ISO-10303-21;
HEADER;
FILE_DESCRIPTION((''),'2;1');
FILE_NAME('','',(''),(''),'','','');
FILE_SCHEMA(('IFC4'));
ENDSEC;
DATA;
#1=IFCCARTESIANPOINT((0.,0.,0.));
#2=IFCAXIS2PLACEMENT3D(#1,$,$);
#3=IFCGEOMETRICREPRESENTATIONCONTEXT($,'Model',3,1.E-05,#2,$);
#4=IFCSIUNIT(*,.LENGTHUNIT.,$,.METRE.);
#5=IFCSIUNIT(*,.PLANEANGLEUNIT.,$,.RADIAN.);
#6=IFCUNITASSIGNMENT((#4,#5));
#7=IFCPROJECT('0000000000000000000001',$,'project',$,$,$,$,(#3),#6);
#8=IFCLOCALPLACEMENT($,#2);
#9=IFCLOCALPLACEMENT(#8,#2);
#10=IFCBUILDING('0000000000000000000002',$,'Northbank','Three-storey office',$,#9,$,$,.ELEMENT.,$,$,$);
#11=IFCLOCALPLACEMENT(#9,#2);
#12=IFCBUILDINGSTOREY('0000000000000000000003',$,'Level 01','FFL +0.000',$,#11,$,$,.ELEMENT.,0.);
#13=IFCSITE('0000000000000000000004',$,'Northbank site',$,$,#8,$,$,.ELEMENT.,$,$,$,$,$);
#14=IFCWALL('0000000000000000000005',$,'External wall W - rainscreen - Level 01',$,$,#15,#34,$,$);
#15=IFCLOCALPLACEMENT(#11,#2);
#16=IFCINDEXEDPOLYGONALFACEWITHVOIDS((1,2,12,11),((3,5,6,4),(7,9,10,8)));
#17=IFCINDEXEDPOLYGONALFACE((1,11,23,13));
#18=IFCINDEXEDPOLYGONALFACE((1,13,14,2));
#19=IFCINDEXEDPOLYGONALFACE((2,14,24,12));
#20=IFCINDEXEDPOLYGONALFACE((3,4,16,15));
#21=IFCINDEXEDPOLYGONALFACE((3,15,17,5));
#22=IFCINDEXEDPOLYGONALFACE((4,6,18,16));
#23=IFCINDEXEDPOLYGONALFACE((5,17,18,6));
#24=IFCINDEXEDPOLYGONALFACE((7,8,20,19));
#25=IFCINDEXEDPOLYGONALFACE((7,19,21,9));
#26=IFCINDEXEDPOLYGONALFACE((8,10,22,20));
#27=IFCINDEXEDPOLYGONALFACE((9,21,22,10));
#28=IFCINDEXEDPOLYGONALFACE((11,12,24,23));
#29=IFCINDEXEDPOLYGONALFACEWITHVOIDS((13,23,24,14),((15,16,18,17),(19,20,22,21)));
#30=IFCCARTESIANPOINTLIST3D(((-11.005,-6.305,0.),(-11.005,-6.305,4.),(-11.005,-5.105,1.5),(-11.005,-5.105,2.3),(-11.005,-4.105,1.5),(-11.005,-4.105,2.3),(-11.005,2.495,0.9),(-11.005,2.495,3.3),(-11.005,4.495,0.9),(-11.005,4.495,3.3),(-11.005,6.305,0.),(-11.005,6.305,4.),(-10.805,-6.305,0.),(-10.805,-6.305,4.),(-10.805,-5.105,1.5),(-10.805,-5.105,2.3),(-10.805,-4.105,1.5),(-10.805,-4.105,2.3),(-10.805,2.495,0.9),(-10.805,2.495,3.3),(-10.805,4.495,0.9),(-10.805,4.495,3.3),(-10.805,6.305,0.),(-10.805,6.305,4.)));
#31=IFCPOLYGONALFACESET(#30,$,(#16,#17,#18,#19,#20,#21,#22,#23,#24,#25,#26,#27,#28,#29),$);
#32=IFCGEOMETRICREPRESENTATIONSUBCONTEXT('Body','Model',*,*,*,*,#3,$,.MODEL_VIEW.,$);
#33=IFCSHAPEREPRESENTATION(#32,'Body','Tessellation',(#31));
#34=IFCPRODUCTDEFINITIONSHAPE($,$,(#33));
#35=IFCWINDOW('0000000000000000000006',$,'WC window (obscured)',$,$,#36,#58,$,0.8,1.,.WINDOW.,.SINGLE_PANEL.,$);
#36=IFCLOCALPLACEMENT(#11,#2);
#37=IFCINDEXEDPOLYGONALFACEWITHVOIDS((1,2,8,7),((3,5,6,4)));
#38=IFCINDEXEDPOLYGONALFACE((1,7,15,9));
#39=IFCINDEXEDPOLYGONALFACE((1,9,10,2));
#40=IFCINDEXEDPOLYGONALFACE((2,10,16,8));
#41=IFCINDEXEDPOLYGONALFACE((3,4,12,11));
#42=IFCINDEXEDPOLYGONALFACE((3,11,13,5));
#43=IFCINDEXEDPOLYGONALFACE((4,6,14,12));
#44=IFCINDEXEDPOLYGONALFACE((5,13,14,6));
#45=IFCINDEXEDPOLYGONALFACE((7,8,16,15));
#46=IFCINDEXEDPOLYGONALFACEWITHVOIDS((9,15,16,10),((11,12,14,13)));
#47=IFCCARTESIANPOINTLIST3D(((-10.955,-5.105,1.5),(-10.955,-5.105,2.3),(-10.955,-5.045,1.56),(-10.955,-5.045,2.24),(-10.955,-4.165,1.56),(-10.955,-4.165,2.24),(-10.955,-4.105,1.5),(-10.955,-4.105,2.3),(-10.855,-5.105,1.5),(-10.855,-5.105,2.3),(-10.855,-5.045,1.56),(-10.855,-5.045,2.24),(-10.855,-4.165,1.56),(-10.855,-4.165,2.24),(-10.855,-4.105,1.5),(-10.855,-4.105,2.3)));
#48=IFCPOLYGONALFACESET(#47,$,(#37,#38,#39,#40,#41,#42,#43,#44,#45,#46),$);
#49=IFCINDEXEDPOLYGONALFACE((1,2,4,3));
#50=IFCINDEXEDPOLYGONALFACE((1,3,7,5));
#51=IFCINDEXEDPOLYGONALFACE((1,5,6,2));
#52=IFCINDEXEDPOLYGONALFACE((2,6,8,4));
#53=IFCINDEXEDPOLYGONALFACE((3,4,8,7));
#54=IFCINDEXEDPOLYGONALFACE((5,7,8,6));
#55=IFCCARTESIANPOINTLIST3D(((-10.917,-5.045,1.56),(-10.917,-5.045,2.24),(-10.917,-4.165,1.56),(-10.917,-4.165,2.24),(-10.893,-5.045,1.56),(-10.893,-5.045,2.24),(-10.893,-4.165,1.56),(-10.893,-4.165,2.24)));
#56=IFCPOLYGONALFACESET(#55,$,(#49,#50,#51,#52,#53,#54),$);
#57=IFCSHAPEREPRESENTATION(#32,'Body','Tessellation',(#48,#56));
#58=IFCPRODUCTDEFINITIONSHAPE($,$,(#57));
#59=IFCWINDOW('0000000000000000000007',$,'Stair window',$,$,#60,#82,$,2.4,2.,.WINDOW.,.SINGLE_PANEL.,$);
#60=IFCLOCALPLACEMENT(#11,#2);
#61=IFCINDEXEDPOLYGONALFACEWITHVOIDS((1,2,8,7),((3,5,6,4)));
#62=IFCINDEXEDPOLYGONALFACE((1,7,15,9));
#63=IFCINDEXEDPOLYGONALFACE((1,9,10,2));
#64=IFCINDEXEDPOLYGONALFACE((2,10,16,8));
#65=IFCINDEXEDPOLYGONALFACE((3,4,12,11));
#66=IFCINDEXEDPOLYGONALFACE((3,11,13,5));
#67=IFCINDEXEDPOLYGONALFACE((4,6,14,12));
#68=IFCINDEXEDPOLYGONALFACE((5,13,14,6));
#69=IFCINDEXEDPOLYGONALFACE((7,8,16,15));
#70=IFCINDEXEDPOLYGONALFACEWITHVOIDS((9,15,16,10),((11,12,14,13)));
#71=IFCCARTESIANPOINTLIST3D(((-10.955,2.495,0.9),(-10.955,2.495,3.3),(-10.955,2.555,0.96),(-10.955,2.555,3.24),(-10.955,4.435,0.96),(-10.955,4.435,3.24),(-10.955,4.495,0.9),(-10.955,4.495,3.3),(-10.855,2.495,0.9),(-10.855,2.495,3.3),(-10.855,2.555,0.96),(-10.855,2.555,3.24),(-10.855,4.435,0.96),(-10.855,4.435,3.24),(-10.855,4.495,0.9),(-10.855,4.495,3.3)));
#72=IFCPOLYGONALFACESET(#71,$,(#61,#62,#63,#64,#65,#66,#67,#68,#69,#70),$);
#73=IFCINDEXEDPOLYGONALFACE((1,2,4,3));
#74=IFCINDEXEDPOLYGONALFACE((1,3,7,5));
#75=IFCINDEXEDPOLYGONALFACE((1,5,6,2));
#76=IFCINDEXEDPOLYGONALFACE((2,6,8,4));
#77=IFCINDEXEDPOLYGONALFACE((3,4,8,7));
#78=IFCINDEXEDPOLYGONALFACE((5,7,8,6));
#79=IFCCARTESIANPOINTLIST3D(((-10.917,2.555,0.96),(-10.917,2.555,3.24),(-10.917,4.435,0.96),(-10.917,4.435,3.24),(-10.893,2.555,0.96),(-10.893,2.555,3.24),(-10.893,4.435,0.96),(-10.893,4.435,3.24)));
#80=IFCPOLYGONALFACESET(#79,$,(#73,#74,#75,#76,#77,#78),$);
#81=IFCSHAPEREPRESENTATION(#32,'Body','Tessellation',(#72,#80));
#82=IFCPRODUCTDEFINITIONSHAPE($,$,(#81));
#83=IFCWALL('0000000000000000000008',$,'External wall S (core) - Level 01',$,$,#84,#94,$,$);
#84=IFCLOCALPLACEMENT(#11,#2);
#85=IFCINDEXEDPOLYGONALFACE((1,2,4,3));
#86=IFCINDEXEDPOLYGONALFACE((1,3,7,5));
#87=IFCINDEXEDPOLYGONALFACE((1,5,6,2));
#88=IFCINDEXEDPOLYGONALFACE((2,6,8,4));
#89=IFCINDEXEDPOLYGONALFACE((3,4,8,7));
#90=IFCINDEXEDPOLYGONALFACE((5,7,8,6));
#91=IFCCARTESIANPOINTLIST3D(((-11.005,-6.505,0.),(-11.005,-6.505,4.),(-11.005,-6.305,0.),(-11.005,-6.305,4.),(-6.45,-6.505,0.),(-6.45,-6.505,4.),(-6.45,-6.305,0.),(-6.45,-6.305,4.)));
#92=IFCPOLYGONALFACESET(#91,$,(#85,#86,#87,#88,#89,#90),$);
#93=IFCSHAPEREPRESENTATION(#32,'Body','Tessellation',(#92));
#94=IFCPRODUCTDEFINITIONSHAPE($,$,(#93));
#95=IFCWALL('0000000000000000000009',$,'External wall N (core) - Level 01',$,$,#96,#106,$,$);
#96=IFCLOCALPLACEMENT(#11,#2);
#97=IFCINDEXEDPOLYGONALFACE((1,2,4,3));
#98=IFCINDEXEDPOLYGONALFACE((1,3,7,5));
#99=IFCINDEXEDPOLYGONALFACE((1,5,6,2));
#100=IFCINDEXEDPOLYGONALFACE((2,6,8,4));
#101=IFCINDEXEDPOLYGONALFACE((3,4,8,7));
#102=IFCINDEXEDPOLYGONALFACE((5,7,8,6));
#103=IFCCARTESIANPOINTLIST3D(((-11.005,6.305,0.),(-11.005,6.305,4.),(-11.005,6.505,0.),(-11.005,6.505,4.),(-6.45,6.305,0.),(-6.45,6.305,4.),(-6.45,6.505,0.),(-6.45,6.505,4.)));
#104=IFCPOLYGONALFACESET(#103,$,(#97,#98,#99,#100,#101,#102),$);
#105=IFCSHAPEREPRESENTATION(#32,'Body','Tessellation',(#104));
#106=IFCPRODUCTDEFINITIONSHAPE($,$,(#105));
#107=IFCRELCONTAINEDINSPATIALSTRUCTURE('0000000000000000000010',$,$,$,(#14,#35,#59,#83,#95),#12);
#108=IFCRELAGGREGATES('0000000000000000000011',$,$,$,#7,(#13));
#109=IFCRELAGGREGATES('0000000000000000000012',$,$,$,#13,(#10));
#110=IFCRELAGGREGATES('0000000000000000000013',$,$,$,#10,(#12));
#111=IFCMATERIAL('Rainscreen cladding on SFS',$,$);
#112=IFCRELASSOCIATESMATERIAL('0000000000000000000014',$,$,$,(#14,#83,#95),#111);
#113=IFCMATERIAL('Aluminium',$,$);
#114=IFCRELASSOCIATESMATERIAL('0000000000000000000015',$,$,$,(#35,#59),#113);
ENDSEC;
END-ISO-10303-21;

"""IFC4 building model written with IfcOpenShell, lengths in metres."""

from ifc_helpers import new_model, si_unit, frame, origin, place, context, subcontext, project, spatial, polyline, outline, extrude, material, element, fill, save


model = new_model("IFC4")

# Units and contexts
model_context = context("Model", 3, precision=1e-05, world=origin())
body_context = subcontext(model_context, "Body", "Model", "MODEL_VIEW")
ifc_project = project(units=[si_unit("LENGTHUNIT", "METRE"), si_unit("PLANEANGLEUNIT", "RADIAN")], contexts=[model_context])

# Site, building, storey
site_placement = place(None, origin())
site = spatial("IfcSite", under=ifc_project, at=site_placement, Name="Northbank site", CompositionType="ELEMENT")
building_placement = place(site_placement, origin())
building = spatial("IfcBuilding", under=site, at=building_placement, Name="Northbank", Description="Three-storey office", CompositionType="ELEMENT")
storey_placement = place(building_placement, origin())
storey = spatial("IfcBuildingStorey", under=building, at=storey_placement, Name="Level 01", Description="FFL +0.000", CompositionType="ELEMENT", Elevation=0.0)

# Shared definitions
ifc_material_1 = material(Name="Aluminium")

# Wall, openings, windows
ifc_material_2 = material(Name="Rainscreen cladding on SFS")
wall_1_placement = place(storey_placement, origin())
wall_1 = element("IfcWall", 1, at=wall_1_placement, inside=storey, material=ifc_material_2, Name="External wall W - rainscreen - Level 01", context=body_context, shape_type="SweptSolid", body=[
    extrude(outline(polyline([(0.0, 0.0), (12.61, 0.0), (12.61, 4.0), (0.0, 4.0), (0.0, 0.0)]), holes=[polyline([(1.2, 1.5), (1.2, 2.3), (2.2, 2.3), (2.2, 1.5), (1.2, 1.5)]), polyline([(8.8, 0.9), (8.8, 3.3), (10.8, 3.3), (10.8, 0.9), (8.8, 0.9)])]), frame((-11.005, -6.305, 0.0), z_axis=(1.0, 0.0, 0.0), x_axis=(0.0, 1.0, 0.0)), (0.0, 0.0, 1.0), 0.2),
])
opening_1_placement = place(storey_placement, origin())
opening_1 = element("IfcOpeningElement", 2, at=opening_1_placement, cuts=wall_1, PredefinedType="OPENING", context=body_context, shape_type="SweptSolid", body=[
    extrude(outline(polyline([(0.0, 0.0), (1.0, 0.0), (1.0, 0.8), (0.0, 0.8), (0.0, 0.0)])), frame((-11.055, -5.105, 1.5), z_axis=(1.0, 0.0, 0.0), x_axis=(0.0, 1.0, 0.0)), (0.0, 0.0, 1.0), 0.3),
])
opening_2_placement = place(storey_placement, origin())
opening_2 = element("IfcOpeningElement", 3, at=opening_2_placement, cuts=wall_1, PredefinedType="OPENING", context=body_context, shape_type="SweptSolid", body=[
    extrude(outline(polyline([(0.0, 0.0), (2.0, 0.0), (2.0, 2.4), (0.0, 2.4), (0.0, 0.0)])), frame((-11.055, 2.495, 0.9), z_axis=(1.0, 0.0, 0.0), x_axis=(0.0, 1.0, 0.0)), (0.0, 0.0, 1.0), 0.3),
])
window_1_placement = place(storey_placement, origin())
window_1 = element("IfcWindow", 4, at=window_1_placement, inside=storey, material=ifc_material_1, Name="WC window (obscured)", OverallHeight=0.8, OverallWidth=1.0, PartitioningType="SINGLE_PANEL", PredefinedType="WINDOW", context=body_context, shape_type="SweptSolid", body=[
    extrude(outline(polyline([(0.0, 0.0), (1.0, 0.0), (1.0, 0.8), (0.0, 0.8), (0.0, 0.0)]), holes=[polyline([(0.06, 0.06), (0.06, 0.74), (0.94, 0.74), (0.94, 0.06), (0.06, 0.06)])]), frame((-10.955, -5.105, 1.5), z_axis=(1.0, 0.0, 0.0), x_axis=(0.0, 1.0, 0.0)), (0.0, 0.0, 1.0), 0.1),
    extrude(outline(polyline([(0.0, 0.0), (0.88, 0.0), (0.88, 0.68), (0.0, 0.68), (0.0, 0.0)])), frame((-10.917, -5.045, 1.56), z_axis=(1.0, 0.0, 0.0), x_axis=(0.0, 1.0, 0.0)), (0.0, 0.0, 1.0), 0.024),
])
fill(opening_1, window_1)
window_2_placement = place(storey_placement, origin())
window_2 = element("IfcWindow", 5, at=window_2_placement, inside=storey, material=ifc_material_1, Name="Stair window", OverallHeight=2.4, OverallWidth=2.0, PartitioningType="SINGLE_PANEL", PredefinedType="WINDOW", context=body_context, shape_type="SweptSolid", body=[
    extrude(outline(polyline([(0.0, 0.0), (2.0, 0.0), (2.0, 2.4), (0.0, 2.4), (0.0, 0.0)]), holes=[polyline([(0.06, 0.06), (0.06, 2.34), (1.94, 2.34), (1.94, 0.06), (0.06, 0.06)])]), frame((-10.955, 2.495, 0.9), z_axis=(1.0, 0.0, 0.0), x_axis=(0.0, 1.0, 0.0)), (0.0, 0.0, 1.0), 0.1),
    extrude(outline(polyline([(0.0, 0.0), (1.88, 0.0), (1.88, 2.28), (0.0, 2.28), (0.0, 0.0)])), frame((-10.917, 2.555, 0.96), z_axis=(1.0, 0.0, 0.0), x_axis=(0.0, 1.0, 0.0)), (0.0, 0.0, 1.0), 0.024),
])
fill(opening_2, window_2)

# Walls
wall_2_placement = place(storey_placement, origin())
element("IfcWall", 6, at=wall_2_placement, inside=storey, material=ifc_material_2, Name="External wall S (core) - Level 01", context=body_context, shape_type="SweptSolid", body=[
    extrude(outline(polyline([(0.0, 0.0), (4.555, 0.0), (4.555, 4.0), (0.0, 4.0), (0.0, 0.0)])), frame((-11.005, -6.305, 0.0), z_axis=(0.0, -1.0, 0.0), x_axis=(1.0, 0.0, 0.0)), (0.0, 0.0, 1.0), 0.2),
])
wall_3_placement = place(storey_placement, origin())
element("IfcWall", 7, at=wall_3_placement, inside=storey, material=ifc_material_2, Name="External wall N (core) - Level 01", context=body_context, shape_type="SweptSolid", body=[
    extrude(outline(polyline([(0.0, 0.0), (4.555, 0.0), (4.555, 4.0), (0.0, 4.0), (0.0, 0.0)])), frame((-11.005, 6.505, 0.0), z_axis=(0.0, -1.0, 0.0), x_axis=(1.0, 0.0, 0.0)), (0.0, 0.0, 1.0), 0.2),
])

save(model, "model.ifc")
